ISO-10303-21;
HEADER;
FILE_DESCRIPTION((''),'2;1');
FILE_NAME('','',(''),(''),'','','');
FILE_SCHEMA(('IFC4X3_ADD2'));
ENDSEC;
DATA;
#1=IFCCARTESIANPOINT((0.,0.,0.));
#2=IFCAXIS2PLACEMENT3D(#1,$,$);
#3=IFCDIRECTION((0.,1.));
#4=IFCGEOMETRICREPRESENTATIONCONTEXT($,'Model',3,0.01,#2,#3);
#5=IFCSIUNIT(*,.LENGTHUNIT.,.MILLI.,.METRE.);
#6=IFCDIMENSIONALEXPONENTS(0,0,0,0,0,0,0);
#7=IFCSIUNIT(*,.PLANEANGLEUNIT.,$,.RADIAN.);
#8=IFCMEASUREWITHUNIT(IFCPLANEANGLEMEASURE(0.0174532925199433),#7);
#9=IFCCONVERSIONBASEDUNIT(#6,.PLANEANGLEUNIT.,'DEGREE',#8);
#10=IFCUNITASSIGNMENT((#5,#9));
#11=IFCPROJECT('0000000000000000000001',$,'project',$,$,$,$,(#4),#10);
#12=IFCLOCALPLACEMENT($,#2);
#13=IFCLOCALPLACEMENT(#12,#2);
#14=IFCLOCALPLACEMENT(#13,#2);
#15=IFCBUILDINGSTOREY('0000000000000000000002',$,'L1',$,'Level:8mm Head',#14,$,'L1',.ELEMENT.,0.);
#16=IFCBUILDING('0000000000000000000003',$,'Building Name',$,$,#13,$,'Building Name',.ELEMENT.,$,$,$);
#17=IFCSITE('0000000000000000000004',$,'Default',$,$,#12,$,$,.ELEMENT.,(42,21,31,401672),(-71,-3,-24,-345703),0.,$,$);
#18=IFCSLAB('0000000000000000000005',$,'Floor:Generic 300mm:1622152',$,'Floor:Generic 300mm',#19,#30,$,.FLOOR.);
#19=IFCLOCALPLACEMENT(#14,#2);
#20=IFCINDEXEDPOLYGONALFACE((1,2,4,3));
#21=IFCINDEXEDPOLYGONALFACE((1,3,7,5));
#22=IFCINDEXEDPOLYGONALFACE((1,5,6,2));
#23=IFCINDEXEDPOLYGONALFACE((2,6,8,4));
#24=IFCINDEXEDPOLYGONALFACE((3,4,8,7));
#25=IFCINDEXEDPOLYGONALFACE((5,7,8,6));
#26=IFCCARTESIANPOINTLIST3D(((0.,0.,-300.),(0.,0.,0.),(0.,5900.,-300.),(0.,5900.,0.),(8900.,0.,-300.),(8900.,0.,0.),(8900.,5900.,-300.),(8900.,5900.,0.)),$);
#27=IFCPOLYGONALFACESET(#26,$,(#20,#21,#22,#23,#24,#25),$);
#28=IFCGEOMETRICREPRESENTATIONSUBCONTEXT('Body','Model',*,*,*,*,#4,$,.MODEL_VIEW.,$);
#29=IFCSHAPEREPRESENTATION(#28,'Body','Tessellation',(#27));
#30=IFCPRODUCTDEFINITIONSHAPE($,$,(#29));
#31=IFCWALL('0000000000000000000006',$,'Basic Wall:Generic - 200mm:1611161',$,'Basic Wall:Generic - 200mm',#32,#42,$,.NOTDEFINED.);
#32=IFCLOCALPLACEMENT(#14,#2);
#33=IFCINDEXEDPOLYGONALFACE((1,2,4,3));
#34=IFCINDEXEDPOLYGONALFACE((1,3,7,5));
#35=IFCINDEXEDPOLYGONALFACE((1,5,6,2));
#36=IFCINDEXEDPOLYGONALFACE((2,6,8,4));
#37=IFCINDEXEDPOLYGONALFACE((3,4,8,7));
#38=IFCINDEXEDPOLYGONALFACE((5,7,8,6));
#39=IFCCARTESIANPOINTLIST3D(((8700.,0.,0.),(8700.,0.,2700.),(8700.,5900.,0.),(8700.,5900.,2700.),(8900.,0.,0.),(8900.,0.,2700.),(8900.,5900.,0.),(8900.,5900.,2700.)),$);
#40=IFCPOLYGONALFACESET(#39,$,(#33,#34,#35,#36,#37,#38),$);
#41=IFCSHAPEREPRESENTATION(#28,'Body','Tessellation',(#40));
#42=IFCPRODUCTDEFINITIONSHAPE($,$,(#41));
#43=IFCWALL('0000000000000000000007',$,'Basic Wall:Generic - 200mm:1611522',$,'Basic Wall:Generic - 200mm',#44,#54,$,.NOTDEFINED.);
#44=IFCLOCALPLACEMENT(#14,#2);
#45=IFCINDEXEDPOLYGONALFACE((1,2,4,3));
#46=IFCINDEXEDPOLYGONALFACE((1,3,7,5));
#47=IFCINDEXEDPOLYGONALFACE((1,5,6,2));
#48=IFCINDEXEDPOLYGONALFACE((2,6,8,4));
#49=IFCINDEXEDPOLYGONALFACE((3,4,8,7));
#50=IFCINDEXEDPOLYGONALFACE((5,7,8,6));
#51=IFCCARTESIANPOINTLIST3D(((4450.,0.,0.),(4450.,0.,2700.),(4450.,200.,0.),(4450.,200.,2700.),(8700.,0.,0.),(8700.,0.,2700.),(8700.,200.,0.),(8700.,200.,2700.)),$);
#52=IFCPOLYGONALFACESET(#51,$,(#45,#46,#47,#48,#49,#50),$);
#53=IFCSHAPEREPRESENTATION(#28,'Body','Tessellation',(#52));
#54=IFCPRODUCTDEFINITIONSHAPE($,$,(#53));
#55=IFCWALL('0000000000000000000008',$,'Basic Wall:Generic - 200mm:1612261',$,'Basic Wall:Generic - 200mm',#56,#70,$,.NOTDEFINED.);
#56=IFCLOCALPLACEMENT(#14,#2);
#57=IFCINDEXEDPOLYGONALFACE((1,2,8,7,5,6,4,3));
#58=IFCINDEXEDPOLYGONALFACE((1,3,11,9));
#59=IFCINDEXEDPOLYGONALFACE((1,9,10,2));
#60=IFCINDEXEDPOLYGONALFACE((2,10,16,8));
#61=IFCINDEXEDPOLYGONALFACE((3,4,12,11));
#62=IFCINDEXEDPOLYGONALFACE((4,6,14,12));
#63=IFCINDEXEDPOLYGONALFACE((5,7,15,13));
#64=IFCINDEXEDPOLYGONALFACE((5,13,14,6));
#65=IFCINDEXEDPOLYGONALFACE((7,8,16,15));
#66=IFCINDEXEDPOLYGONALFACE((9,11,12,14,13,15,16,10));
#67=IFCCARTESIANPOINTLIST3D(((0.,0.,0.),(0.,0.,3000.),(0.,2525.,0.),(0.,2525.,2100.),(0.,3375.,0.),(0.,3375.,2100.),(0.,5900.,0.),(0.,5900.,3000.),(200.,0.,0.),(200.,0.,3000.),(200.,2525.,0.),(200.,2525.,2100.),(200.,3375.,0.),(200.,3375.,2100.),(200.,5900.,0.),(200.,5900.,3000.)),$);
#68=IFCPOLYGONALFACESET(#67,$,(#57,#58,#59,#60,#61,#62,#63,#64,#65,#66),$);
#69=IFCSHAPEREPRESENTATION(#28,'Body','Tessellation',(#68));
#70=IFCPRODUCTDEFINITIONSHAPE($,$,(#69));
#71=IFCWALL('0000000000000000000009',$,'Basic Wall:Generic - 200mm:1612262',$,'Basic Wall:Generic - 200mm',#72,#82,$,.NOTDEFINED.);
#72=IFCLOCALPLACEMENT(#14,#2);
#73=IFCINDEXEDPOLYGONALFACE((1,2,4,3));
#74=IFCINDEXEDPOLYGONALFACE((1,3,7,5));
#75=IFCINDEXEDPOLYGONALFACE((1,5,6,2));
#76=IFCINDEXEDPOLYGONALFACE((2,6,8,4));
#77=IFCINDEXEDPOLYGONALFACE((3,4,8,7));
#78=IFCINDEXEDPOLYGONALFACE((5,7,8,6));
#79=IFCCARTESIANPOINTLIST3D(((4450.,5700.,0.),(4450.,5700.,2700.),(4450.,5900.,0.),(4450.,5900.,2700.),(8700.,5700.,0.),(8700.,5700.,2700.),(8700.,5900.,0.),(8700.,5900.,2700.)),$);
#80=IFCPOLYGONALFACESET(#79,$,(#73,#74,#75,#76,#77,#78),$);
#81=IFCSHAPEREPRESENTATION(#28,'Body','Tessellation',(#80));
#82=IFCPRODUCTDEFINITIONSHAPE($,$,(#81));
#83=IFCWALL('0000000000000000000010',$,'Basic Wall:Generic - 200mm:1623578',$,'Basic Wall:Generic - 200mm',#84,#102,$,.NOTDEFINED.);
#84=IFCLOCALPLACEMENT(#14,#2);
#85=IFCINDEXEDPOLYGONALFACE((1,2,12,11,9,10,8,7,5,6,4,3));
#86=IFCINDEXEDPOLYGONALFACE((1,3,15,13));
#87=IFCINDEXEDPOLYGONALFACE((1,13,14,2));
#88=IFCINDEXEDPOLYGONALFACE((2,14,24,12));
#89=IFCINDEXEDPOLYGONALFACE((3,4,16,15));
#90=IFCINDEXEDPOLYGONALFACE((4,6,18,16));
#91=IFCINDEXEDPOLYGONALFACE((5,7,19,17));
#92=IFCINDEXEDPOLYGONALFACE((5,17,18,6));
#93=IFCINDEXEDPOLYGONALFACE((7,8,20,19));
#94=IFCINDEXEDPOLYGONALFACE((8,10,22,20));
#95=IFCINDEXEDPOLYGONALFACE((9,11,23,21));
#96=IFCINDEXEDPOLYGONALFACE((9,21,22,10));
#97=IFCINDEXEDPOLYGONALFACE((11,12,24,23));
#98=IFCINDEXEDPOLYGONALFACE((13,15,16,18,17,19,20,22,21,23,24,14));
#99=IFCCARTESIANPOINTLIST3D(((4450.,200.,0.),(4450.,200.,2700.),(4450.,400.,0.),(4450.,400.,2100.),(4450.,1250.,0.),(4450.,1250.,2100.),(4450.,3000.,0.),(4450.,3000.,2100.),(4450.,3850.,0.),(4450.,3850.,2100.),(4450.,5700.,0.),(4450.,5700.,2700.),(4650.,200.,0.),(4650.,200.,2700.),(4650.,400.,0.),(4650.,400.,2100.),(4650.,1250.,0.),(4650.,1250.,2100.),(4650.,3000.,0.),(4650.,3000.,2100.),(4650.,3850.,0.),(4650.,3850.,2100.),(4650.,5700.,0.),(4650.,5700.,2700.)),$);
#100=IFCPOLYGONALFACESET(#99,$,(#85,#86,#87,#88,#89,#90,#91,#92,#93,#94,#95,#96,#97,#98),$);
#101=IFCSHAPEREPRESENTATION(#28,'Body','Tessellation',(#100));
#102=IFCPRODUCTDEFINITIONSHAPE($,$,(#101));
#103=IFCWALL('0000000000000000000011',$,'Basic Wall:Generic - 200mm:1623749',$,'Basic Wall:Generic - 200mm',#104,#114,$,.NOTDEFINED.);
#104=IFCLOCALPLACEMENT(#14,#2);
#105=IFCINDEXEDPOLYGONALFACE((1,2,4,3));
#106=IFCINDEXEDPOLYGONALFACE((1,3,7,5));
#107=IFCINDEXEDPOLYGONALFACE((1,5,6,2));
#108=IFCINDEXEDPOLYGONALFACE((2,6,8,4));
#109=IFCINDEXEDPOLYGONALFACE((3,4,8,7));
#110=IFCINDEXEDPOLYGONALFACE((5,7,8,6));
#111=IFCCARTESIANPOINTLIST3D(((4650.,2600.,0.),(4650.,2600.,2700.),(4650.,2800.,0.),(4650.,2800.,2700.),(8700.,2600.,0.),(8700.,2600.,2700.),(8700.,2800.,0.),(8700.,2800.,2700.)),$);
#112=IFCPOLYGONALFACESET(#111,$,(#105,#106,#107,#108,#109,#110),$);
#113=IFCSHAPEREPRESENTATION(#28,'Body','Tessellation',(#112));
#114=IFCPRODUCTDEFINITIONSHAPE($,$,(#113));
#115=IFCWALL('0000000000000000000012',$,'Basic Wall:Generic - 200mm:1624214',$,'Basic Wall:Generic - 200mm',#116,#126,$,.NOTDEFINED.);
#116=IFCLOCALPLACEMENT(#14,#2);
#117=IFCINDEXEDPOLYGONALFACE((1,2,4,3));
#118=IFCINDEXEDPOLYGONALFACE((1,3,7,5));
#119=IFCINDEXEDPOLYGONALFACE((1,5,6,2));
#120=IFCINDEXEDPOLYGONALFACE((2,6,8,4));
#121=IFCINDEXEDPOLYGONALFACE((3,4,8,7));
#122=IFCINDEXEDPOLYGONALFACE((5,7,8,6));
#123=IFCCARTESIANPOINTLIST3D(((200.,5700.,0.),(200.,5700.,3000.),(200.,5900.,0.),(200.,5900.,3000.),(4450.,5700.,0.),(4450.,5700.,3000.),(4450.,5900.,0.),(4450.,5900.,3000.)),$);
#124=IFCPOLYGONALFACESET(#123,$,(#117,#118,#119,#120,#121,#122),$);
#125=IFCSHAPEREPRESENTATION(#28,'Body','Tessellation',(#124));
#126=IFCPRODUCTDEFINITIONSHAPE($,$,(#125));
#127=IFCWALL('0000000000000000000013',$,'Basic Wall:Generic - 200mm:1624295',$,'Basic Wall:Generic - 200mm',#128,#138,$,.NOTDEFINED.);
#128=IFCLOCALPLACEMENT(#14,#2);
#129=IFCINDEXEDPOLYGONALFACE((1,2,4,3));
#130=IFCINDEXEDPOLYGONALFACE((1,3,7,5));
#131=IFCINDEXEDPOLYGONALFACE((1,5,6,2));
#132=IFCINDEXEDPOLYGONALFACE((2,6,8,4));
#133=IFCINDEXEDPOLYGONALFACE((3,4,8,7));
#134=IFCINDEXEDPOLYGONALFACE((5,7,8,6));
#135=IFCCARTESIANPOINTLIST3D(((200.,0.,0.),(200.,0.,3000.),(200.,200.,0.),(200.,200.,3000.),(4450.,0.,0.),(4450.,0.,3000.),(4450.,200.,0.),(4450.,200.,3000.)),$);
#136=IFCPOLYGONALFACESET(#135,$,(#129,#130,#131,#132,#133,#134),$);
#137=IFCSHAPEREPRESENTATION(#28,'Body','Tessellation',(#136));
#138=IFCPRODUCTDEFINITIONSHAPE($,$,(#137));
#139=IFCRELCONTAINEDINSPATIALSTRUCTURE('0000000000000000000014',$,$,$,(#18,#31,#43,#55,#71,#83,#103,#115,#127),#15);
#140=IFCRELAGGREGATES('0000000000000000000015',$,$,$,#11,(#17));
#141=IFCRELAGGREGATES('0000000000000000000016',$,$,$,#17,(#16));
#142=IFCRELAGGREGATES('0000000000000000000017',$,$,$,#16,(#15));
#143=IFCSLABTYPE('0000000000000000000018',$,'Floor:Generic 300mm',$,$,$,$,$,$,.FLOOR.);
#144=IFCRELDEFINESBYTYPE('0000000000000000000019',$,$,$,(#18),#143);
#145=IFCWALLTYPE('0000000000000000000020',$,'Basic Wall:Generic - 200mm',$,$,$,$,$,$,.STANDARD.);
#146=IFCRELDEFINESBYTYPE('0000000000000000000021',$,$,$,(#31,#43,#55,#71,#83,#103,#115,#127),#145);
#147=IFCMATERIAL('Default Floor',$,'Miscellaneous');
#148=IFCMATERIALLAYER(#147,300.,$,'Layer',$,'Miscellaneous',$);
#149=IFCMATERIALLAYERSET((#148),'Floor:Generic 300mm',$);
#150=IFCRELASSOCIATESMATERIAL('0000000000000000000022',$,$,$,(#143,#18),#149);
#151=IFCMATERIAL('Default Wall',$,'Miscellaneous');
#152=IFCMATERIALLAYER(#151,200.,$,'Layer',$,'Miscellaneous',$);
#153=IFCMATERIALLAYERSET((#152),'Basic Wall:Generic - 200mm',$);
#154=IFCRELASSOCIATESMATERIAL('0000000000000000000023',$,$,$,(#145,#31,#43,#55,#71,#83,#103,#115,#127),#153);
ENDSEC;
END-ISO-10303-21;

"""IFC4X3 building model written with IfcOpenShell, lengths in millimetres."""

from ifc_helpers import new_model, entity, si_unit, converted_unit, direction, frame, frame_2d, origin, origin_2d_with_axis, place, context, subcontext, project, spatial, polyline, rectangle, extrude, clip, bounded_halfspace, material, layer, layer_set, layer_usage, type_object, element, save


model = new_model("IFC4X3")

# Units and contexts
model_context = context("Model", 3, precision=0.01, world=origin(), true_north=direction((0.0, 1.0)))
body_context = subcontext(model_context, "Body", "Model", "MODEL_VIEW")
ifc_project = project(units=[si_unit("LENGTHUNIT", "METRE", prefix="MILLI"), converted_unit("PLANEANGLEUNIT", "DEGREE", entity("IfcPlaneAngleMeasure", 0.0174532925199433), si_unit("PLANEANGLEUNIT", "RADIAN"), dimensions=[0, 0, 0, 0, 0, 0, 0])], contexts=[model_context])

# Site, building, storey
site_placement = place(None, origin())
site = spatial("IfcSite", under=ifc_project, at=site_placement, Name="Default", CompositionType="ELEMENT", RefLatitude=(42, 21, 31, 401672), RefLongitude=(-71, -3, -24, -345703), RefElevation=0.0)
building_placement = place(site_placement, origin())
building = spatial("IfcBuilding", under=site, at=building_placement, Name="Building Name", LongName="Building Name", CompositionType="ELEMENT")
storey_placement = place(building_placement, origin())
storey = spatial("IfcBuildingStorey", under=building, at=storey_placement, Name="L1", ObjectType="Level:8mm Head", LongName="L1", CompositionType="ELEMENT", Elevation=0.0)

# Slab
ifc_material_1 = material(Name="Default Floor", Category="Miscellaneous")
ifc_layer_1 = layer(ifc_material_1, 300.0, Name="Layer", Category="Miscellaneous")
ifc_layer_set_1 = layer_set([ifc_layer_1], Name="Floor:Generic 300mm")
ifc_layer_usage = layer_usage(ifc_layer_set_1, "AXIS3", "POSITIVE", 0.0)
slab_type = type_object("IfcSlabType", Name="Floor:Generic 300mm", PredefinedType="FLOOR", material=ifc_layer_set_1)
slab_placement = place(storey_placement, origin())
element("IfcSlab", 1, at=slab_placement, inside=storey, type_object=slab_type, material=ifc_layer_usage, Name="Floor:Generic 300mm:1622152", ObjectType="Floor:Generic 300mm", PredefinedType="FLOOR", context=body_context, shape_type="SweptSolid", body=[
    extrude(rectangle(XDim=5900.0, YDim=8900.0, at=origin_2d_with_axis()), frame((4450.0, 2950.0, 0.0), z_axis=(0.0, 0.0, -1.0), x_axis=(0.0, 1.0, 0.0)), (0.0, 0.0, 1.0), 300.0),
])

# Walls
ifc_material_2 = material(Name="Default Wall", Category="Miscellaneous")
ifc_layer_2 = layer(ifc_material_2, 200.0, Name="Layer", Category="Miscellaneous")
ifc_layer_set_2 = layer_set([ifc_layer_2], Name="Basic Wall:Generic - 200mm")
wall_type = type_object("IfcWallType", Name="Basic Wall:Generic - 200mm", PredefinedType="STANDARD", material=ifc_layer_set_2)
wall_1_placement = place(storey_placement, frame((8800.0, 0.0, 0.0), z_axis=(0.0, 0.0, 1.0), x_axis=(0.0, 1.0, 0.0)))
element("IfcWall", 2, at=wall_1_placement, inside=storey, type_object=wall_type, material=ifc_layer_set_2, Name="Basic Wall:Generic - 200mm:1611161", ObjectType="Basic Wall:Generic - 200mm", PredefinedType="NOTDEFINED", context=body_context, shape_type="Clipping", body=[
    clip(extrude(rectangle(XDim=5900.0, YDim=200.0, at=frame_2d((2950.0, 0.0), x_axis=(-1.0, 0.0))), origin(), (0.0, 0.0, 1.0), 2700.0), bounded_halfspace(frame((0.0, -100.0, 2700.0), z_axis=(0.0, 0.0, -1.0), x_axis=(0.0, 1.0, 0.0)), True, frame((0.0, -100.0, 2700.0)), polyline([(0.0, 0.0), (5900.0, 0.0), (5900.0, 200.0), (5700.0, 200.0), (2800.0, 200.0), (2600.0, 200.0), (200.0, 200.0), (0.0, 200.0), (0.0, 0.0)]))),
])
wall_2_placement = place(storey_placement, frame((4450.0, 100.0, 0.0)))
element("IfcWall", 3, at=wall_2_placement, inside=storey, type_object=wall_type, material=ifc_layer_set_2, Name="Basic Wall:Generic - 200mm:1611522", ObjectType="Basic Wall:Generic - 200mm", PredefinedType="NOTDEFINED", context=body_context, shape_type="Clipping", body=[
    clip(extrude(rectangle(XDim=4250.0, YDim=200.0, at=frame_2d((2125.0, 0.0), x_axis=(-1.0, 0.0))), origin(), (0.0, 0.0, 1.0), 2700.0), bounded_halfspace(frame((0.0, -100.0, 2700.0), z_axis=(0.0, 0.0, -1.0), x_axis=(-1.0, 0.0, 0.0)), True, frame((0.0, -100.0, 2700.0)), polyline([(0.0, 0.0), (4250.0, 0.0), (4250.0, 200.0), (200.0, 200.0), (0.0, 200.0), (0.0, 0.0)]))),
])

# Wall, opening
wall_3_placement = place(storey_placement, frame((100.0, 5900.0, 0.0), z_axis=(0.0, 0.0, 1.0), x_axis=(0.0, -1.0, 0.0)))
wall_3 = element("IfcWall", 4, at=wall_3_placement, inside=storey, type_object=wall_type, material=ifc_layer_set_2, Name="Basic Wall:Generic - 200mm:1612261", ObjectType="Basic Wall:Generic - 200mm", PredefinedType="NOTDEFINED", context=body_context, shape_type="SweptSolid", body=[
    extrude(rectangle(XDim=5900.0, YDim=200.0, at=frame_2d((2950.0, 0.0), x_axis=(-1.0, 0.0))), origin(), (0.0, 0.0, 1.0), 3000.0),
])
opening_1_placement = place(wall_3_placement, frame((2525.0, -100.0, 0.0)))
element("IfcOpeningElement", 5, at=opening_1_placement, cuts=wall_3, PredefinedType="OPENING", context=body_context, shape_type="SweptSolid", body=[
    extrude(rectangle(XDim=2100.0, YDim=850.0, at=frame_2d((1050.0, 425.0), x_axis=(1.0, 0.0))), frame((0.0, 0.0, 0.0), z_axis=(0.0, 1.0, 0.0), x_axis=(0.0, 0.0, 1.0)), (0.0, 0.0, 1.0), 200.0),
])

# Wall
wall_4_placement = place(storey_placement, frame((8700.0, 5800.0, 0.0), z_axis=(0.0, 0.0, 1.0), x_axis=(-1.0, 0.0, 0.0)))
element("IfcWall", 6, at=wall_4_placement, inside=storey, type_object=wall_type, material=ifc_layer_set_2, Name="Basic Wall:Generic - 200mm:1612262", ObjectType="Basic Wall:Generic - 200mm", PredefinedType="NOTDEFINED", context=body_context, shape_type="Clipping", body=[
    clip(extrude(rectangle(XDim=4250.0, YDim=200.0, at=frame_2d((2125.0, 0.0), x_axis=(-1.0, 0.0))), origin(), (0.0, 0.0, 1.0), 2700.0), bounded_halfspace(frame((0.0, -100.0, 2700.0), z_axis=(0.0, 0.0, -1.0), x_axis=(1.0, 0.0, 0.0)), True, frame((0.0, -100.0, 2700.0)), polyline([(0.0, 0.0), (4250.0, 0.0), (4250.0, 200.0), (4050.0, 200.0), (0.0, 200.0), (0.0, 0.0)]))),
])

# Wall, openings
wall_5_placement = place(storey_placement, frame((4550.0, 5700.0, 0.0), z_axis=(0.0, 0.0, 1.0), x_axis=(0.0, -1.0, 0.0)))
wall_5 = element("IfcWall", 7, at=wall_5_placement, inside=storey, type_object=wall_type, material=ifc_layer_set_2, Name="Basic Wall:Generic - 200mm:1623578", ObjectType="Basic Wall:Generic - 200mm", PredefinedType="NOTDEFINED", context=body_context, shape_type="Clipping", body=[
    clip(extrude(rectangle(XDim=5500.0, YDim=200.0, at=frame_2d((2750.0, 0.0), x_axis=(1.0, 0.0))), origin(), (0.0, 0.0, 1.0), 2700.0), bounded_halfspace(frame((0.0, -100.0, 2700.0), z_axis=(0.0, 0.0, -1.0), x_axis=(0.0, -1.0, 0.0)), True, frame((0.0, -100.0, 2700.0)), polyline([(0.0, 0.0), (5500.0, 0.0), (5500.0, 200.0), (3100.0, 200.0), (2900.0, 200.0), (0.0, 200.0), (0.0, 0.0)]))),
])
opening_2_placement = place(wall_5_placement, frame((1850.0, -100.0, 0.0)))
element("IfcOpeningElement", 8, at=opening_2_placement, cuts=wall_5, PredefinedType="OPENING", context=body_context, shape_type="SweptSolid", body=[
    extrude(rectangle(XDim=2100.0, YDim=850.0, at=frame_2d((1050.0, 425.0), x_axis=(1.0, 0.0))), frame((0.0, 0.0, 0.0), z_axis=(0.0, 1.0, 0.0), x_axis=(0.0, 0.0, 1.0)), (0.0, 0.0, 1.0), 200.0),
])
opening_3_placement = place(wall_5_placement, frame((4450.0, -100.0, 0.0)))
element("IfcOpeningElement", 9, at=opening_3_placement, cuts=wall_5, PredefinedType="OPENING", context=body_context, shape_type="SweptSolid", body=[
    extrude(rectangle(XDim=2100.0, YDim=850.0, at=frame_2d((1050.0, 425.0), x_axis=(1.0, 0.0))), frame((0.0, 0.0, 0.0), z_axis=(0.0, 1.0, 0.0), x_axis=(0.0, 0.0, 1.0)), (0.0, 0.0, 1.0), 200.0),
])

# Walls
wall_6_placement = place(storey_placement, frame((4650.0, 2700.0, 0.0)))
element("IfcWall", 10, at=wall_6_placement, inside=storey, type_object=wall_type, material=ifc_layer_set_2, Name="Basic Wall:Generic - 200mm:1623749", ObjectType="Basic Wall:Generic - 200mm", PredefinedType="NOTDEFINED", context=body_context, shape_type="Clipping", body=[
    clip(extrude(rectangle(XDim=4050.0, YDim=200.0, at=frame_2d((2025.0, 0.0), x_axis=(-1.0, 0.0))), origin(), (0.0, 0.0, 1.0), 2700.0), bounded_halfspace(frame((0.0, -100.0, 2700.0), z_axis=(0.0, 0.0, -1.0), x_axis=(-1.0, 0.0, 0.0)), True, frame((0.0, -100.0, 2700.0)), polyline([(0.0, 0.0), (4050.0, 0.0), (4050.0, 200.0), (0.0, 200.0), (0.0, 0.0)]))),
])
wall_7_placement = place(storey_placement, frame((4450.0, 5800.0, 0.0), z_axis=(0.0, 0.0, 1.0), x_axis=(-1.0, 0.0, 0.0)))
element("IfcWall", 11, at=wall_7_placement, inside=storey, type_object=wall_type, material=ifc_layer_set_2, Name="Basic Wall:Generic - 200mm:1624214", ObjectType="Basic Wall:Generic - 200mm", PredefinedType="NOTDEFINED", context=body_context, shape_type="SweptSolid", body=[
    extrude(rectangle(XDim=4250.0, YDim=200.0, at=frame_2d((2125.0, 0.0), x_axis=(-1.0, 0.0))), origin(), (0.0, 0.0, 1.0), 3000.0),
])
wall_8_placement = place(storey_placement, frame((200.0, 100.0, 0.0)))
element("IfcWall", 12, at=wall_8_placement, inside=storey, type_object=wall_type, material=ifc_layer_set_2, Name="Basic Wall:Generic - 200mm:1624295", ObjectType="Basic Wall:Generic - 200mm", PredefinedType="NOTDEFINED", context=body_context, shape_type="SweptSolid", body=[
    extrude(rectangle(XDim=4250.0, YDim=200.0, at=frame_2d((2125.0, 0.0), x_axis=(-1.0, 0.0))), origin(), (0.0, 0.0, 1.0), 3000.0),
])

save(model, "model.ifc")
